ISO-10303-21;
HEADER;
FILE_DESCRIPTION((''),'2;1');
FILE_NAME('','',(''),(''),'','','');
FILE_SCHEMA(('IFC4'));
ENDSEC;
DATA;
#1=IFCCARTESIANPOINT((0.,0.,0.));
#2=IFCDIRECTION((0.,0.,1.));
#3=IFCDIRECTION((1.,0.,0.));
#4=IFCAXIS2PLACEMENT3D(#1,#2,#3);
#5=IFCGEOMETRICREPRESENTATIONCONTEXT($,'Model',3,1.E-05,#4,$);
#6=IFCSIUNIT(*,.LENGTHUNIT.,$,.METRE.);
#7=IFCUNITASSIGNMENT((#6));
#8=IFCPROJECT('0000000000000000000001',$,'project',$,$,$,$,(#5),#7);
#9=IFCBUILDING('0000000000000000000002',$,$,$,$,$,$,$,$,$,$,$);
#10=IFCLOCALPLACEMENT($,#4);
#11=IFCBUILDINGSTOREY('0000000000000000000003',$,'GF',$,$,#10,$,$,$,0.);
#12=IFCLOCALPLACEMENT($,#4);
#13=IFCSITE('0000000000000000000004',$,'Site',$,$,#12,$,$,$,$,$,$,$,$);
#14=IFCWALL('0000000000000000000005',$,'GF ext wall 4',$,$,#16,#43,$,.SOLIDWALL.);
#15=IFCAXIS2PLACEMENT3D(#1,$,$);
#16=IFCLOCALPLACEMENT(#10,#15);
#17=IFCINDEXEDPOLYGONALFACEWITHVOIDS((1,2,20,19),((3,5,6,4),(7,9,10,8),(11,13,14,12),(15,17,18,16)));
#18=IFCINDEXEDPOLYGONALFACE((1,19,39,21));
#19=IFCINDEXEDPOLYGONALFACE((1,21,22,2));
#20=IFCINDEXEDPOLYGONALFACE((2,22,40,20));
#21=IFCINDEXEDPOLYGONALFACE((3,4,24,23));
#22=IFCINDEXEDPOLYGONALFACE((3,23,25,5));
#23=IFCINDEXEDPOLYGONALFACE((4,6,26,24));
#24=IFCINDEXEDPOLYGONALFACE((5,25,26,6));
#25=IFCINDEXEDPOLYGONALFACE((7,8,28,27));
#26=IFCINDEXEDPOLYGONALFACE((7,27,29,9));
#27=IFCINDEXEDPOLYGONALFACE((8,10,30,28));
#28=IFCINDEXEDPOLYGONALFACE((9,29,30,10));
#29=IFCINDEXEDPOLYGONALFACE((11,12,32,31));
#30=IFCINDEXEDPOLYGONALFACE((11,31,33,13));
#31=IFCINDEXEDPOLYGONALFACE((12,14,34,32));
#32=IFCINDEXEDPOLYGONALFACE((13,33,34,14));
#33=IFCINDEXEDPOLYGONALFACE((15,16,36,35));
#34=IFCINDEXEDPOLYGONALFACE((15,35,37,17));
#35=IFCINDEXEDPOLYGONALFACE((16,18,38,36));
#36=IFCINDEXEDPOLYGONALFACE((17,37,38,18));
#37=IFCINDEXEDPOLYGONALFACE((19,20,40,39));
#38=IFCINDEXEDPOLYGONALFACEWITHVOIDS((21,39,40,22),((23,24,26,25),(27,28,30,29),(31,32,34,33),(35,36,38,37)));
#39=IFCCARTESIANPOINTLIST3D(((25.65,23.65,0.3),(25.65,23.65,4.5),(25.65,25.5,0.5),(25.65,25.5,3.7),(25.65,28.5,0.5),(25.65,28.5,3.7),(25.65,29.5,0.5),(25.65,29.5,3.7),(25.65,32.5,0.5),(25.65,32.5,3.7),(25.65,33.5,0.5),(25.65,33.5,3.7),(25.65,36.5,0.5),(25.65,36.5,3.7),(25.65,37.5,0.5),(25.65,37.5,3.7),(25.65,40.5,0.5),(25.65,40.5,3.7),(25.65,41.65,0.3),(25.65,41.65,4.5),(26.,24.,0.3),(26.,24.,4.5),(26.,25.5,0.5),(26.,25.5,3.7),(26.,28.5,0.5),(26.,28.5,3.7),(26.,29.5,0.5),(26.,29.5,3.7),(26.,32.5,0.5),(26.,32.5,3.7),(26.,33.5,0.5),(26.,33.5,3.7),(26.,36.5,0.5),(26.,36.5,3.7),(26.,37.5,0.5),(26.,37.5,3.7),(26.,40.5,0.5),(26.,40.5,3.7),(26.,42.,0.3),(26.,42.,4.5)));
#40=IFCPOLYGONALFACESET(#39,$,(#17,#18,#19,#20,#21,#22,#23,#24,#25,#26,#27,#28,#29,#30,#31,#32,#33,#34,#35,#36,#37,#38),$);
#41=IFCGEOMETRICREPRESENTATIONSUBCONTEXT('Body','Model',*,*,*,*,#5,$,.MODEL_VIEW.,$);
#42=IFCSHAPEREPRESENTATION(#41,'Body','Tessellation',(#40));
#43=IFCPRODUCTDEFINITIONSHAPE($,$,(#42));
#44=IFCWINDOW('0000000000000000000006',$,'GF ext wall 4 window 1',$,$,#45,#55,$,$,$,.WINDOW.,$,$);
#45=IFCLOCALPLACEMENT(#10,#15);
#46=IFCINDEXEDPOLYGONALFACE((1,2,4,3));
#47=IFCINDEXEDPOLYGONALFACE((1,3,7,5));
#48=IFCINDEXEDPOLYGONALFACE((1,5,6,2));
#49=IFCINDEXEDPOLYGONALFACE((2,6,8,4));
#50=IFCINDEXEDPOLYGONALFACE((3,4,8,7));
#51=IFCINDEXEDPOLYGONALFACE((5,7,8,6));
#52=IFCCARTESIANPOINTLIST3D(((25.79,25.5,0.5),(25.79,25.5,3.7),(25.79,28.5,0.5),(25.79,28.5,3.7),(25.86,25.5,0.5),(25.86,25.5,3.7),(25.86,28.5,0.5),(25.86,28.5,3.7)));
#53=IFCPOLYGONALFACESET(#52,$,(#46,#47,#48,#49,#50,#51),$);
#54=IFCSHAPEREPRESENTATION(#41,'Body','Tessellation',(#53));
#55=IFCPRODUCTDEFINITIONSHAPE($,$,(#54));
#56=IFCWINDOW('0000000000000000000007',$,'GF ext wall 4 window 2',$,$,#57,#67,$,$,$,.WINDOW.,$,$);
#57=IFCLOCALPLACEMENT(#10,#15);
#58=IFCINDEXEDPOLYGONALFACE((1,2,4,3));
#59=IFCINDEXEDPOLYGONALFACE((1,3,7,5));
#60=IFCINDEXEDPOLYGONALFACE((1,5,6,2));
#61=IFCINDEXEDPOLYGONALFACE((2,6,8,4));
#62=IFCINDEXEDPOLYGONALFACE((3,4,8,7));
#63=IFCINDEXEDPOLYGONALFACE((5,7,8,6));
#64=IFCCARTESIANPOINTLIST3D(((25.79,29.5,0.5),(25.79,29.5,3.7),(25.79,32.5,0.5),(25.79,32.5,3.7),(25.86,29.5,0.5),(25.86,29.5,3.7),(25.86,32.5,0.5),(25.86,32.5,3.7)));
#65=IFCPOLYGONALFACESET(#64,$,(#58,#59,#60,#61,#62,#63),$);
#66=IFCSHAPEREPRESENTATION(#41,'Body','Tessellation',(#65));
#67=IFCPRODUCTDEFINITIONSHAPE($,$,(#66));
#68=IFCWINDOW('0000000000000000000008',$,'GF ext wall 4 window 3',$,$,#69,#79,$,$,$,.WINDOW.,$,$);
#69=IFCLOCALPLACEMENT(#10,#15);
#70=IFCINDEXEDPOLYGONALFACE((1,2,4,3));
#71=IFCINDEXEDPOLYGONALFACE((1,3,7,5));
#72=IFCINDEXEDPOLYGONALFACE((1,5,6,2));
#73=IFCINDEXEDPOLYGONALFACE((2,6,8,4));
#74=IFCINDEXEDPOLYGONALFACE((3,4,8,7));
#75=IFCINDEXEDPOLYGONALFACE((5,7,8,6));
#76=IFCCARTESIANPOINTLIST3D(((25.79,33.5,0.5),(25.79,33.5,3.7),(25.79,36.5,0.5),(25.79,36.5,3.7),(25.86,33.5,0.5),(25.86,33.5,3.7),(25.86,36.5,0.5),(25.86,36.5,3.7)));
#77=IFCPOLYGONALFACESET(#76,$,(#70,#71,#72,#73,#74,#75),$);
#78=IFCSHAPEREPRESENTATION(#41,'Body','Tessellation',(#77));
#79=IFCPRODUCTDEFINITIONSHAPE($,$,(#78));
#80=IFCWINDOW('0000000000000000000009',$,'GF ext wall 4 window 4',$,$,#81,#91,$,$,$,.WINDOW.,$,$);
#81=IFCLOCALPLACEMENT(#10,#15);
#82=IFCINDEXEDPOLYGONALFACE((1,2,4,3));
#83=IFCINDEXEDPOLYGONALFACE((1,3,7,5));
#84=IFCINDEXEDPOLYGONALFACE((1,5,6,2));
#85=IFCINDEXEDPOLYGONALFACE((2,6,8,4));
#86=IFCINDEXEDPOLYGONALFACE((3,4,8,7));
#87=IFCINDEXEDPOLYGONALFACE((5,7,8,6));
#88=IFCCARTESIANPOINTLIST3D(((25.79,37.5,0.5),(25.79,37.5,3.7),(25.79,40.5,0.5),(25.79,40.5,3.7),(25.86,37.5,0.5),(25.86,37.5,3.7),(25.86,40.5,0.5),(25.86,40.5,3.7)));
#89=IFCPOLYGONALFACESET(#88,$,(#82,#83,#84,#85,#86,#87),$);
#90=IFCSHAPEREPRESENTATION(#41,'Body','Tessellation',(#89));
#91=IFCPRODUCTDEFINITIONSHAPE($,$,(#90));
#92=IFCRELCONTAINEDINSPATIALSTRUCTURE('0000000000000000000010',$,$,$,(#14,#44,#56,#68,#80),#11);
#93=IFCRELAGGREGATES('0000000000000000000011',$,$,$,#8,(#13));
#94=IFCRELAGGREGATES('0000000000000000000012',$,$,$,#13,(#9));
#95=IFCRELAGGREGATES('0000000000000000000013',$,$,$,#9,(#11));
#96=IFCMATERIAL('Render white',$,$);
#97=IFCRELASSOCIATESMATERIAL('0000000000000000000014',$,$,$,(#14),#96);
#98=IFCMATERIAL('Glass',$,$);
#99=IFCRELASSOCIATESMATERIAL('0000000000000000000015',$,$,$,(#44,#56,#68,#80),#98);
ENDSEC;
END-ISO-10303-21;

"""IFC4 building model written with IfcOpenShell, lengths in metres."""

from ifc_helpers import new_model, si_unit, frame, origin_with_axes, place, context, subcontext, project, spatial, polyline, outline, extrude, material, element, fill, save


model = new_model("IFC4")

# Units and contexts
model_context = context("Model", 3, precision=1e-05, world=origin_with_axes())
body_context = subcontext(model_context, "Body", "Model", "MODEL_VIEW")
ifc_project = project(units=[si_unit("LENGTHUNIT", "METRE")], contexts=[model_context])

# Site, building, storey
site_placement = place(None, origin_with_axes())
site = spatial("IfcSite", under=ifc_project, at=site_placement, Name="Site")
building = spatial("IfcBuilding", under=site)
storey_placement = place(None, origin_with_axes())
storey = spatial("IfcBuildingStorey", under=building, at=storey_placement, Name="GF", Elevation=0.0)

# Wall, openings, windows
ifc_material_1 = material(Name="Render white")
ifc_material_2 = material(Name="Glass")
wall_1_placement = place(storey_placement, origin_with_axes())
wall_1 = element("IfcWall", 1, at=wall_1_placement, inside=storey, material=ifc_material_1, Name="GF ext wall 4", PredefinedType="SOLIDWALL", context=body_context, shape_type="SweptSolid", body=[
    extrude(outline(polyline([(26.0, 24.0), (26.0, 42.0), (25.65, 41.65), (25.65, 23.65), (26.0, 24.0)])), frame((0.0, 0.0, 0.3), z_axis=(0.0, 0.0, 1.0), x_axis=(1.0, 0.0, 0.0)), (0.0, 0.0, 1.0), 4.2),
])
opening_1_placement = place(wall_1_placement, origin_with_axes())
opening_1 = element("IfcOpeningElement", 2, at=opening_1_placement, cuts=wall_1, context=body_context, shape_type="SweptSolid", body=[
    extrude(outline(polyline([(26.05, 25.5), (26.05, 28.5), (25.6, 28.5), (25.6, 25.5), (26.05, 25.5)])), frame((0.0, 0.0, 0.5), z_axis=(0.0, 0.0, 1.0), x_axis=(1.0, 0.0, 0.0)), (0.0, 0.0, 1.0), 3.2),
])
opening_2_placement = place(wall_1_placement, origin_with_axes())
opening_2 = element("IfcOpeningElement", 3, at=opening_2_placement, cuts=wall_1, context=body_context, shape_type="SweptSolid", body=[
    extrude(outline(polyline([(26.05, 29.5), (26.05, 32.5), (25.6, 32.5), (25.6, 29.5), (26.05, 29.5)])), frame((0.0, 0.0, 0.5), z_axis=(0.0, 0.0, 1.0), x_axis=(1.0, 0.0, 0.0)), (0.0, 0.0, 1.0), 3.2),
])
opening_3_placement = place(wall_1_placement, origin_with_axes())
opening_3 = element("IfcOpeningElement", 4, at=opening_3_placement, cuts=wall_1, context=body_context, shape_type="SweptSolid", body=[
    extrude(outline(polyline([(26.05, 33.5), (26.05, 36.5), (25.6, 36.5), (25.6, 33.5), (26.05, 33.5)])), frame((0.0, 0.0, 0.5), z_axis=(0.0, 0.0, 1.0), x_axis=(1.0, 0.0, 0.0)), (0.0, 0.0, 1.0), 3.2),
])
opening_4_placement = place(wall_1_placement, origin_with_axes())
opening_4 = element("IfcOpeningElement", 5, at=opening_4_placement, cuts=wall_1, context=body_context, shape_type="SweptSolid", body=[
    extrude(outline(polyline([(26.05, 37.5), (26.05, 40.5), (25.6, 40.5), (25.6, 37.5), (26.05, 37.5)])), frame((0.0, 0.0, 0.5), z_axis=(0.0, 0.0, 1.0), x_axis=(1.0, 0.0, 0.0)), (0.0, 0.0, 1.0), 3.2),
])
window_1_placement = place(storey_placement, origin_with_axes())
window_1 = element("IfcWindow", 6, at=window_1_placement, inside=storey, material=ifc_material_2, Name="GF ext wall 4 window 1", PredefinedType="WINDOW", context=body_context, shape_type="SweptSolid", body=[
    extrude(outline(polyline([(25.86, 25.5), (25.86, 28.5), (25.79, 28.5), (25.79, 25.5), (25.86, 25.5)])), frame((0.0, 0.0, 0.5), z_axis=(0.0, 0.0, 1.0), x_axis=(1.0, 0.0, 0.0)), (0.0, 0.0, 1.0), 3.2),
])
fill(opening_1, window_1)
window_2_placement = place(storey_placement, origin_with_axes())
window_2 = element("IfcWindow", 7, at=window_2_placement, inside=storey, material=ifc_material_2, Name="GF ext wall 4 window 2", PredefinedType="WINDOW", context=body_context, shape_type="SweptSolid", body=[
    extrude(outline(polyline([(25.86, 29.5), (25.86, 32.5), (25.79, 32.5), (25.79, 29.5), (25.86, 29.5)])), frame((0.0, 0.0, 0.5), z_axis=(0.0, 0.0, 1.0), x_axis=(1.0, 0.0, 0.0)), (0.0, 0.0, 1.0), 3.2),
])
fill(opening_2, window_2)
window_3_placement = place(storey_placement, origin_with_axes())
window_3 = element("IfcWindow", 8, at=window_3_placement, inside=storey, material=ifc_material_2, Name="GF ext wall 4 window 3", PredefinedType="WINDOW", context=body_context, shape_type="SweptSolid", body=[
    extrude(outline(polyline([(25.86, 33.5), (25.86, 36.5), (25.79, 36.5), (25.79, 33.5), (25.86, 33.5)])), frame((0.0, 0.0, 0.5), z_axis=(0.0, 0.0, 1.0), x_axis=(1.0, 0.0, 0.0)), (0.0, 0.0, 1.0), 3.2),
])
fill(opening_3, window_3)
window_4_placement = place(storey_placement, origin_with_axes())
window_4 = element("IfcWindow", 9, at=window_4_placement, inside=storey, material=ifc_material_2, Name="GF ext wall 4 window 4", PredefinedType="WINDOW", context=body_context, shape_type="SweptSolid", body=[
    extrude(outline(polyline([(25.86, 37.5), (25.86, 40.5), (25.79, 40.5), (25.79, 37.5), (25.86, 37.5)])), frame((0.0, 0.0, 0.5), z_axis=(0.0, 0.0, 1.0), x_axis=(1.0, 0.0, 0.0)), (0.0, 0.0, 1.0), 3.2),
])
fill(opening_4, window_4)

save(model, "model.ifc")
